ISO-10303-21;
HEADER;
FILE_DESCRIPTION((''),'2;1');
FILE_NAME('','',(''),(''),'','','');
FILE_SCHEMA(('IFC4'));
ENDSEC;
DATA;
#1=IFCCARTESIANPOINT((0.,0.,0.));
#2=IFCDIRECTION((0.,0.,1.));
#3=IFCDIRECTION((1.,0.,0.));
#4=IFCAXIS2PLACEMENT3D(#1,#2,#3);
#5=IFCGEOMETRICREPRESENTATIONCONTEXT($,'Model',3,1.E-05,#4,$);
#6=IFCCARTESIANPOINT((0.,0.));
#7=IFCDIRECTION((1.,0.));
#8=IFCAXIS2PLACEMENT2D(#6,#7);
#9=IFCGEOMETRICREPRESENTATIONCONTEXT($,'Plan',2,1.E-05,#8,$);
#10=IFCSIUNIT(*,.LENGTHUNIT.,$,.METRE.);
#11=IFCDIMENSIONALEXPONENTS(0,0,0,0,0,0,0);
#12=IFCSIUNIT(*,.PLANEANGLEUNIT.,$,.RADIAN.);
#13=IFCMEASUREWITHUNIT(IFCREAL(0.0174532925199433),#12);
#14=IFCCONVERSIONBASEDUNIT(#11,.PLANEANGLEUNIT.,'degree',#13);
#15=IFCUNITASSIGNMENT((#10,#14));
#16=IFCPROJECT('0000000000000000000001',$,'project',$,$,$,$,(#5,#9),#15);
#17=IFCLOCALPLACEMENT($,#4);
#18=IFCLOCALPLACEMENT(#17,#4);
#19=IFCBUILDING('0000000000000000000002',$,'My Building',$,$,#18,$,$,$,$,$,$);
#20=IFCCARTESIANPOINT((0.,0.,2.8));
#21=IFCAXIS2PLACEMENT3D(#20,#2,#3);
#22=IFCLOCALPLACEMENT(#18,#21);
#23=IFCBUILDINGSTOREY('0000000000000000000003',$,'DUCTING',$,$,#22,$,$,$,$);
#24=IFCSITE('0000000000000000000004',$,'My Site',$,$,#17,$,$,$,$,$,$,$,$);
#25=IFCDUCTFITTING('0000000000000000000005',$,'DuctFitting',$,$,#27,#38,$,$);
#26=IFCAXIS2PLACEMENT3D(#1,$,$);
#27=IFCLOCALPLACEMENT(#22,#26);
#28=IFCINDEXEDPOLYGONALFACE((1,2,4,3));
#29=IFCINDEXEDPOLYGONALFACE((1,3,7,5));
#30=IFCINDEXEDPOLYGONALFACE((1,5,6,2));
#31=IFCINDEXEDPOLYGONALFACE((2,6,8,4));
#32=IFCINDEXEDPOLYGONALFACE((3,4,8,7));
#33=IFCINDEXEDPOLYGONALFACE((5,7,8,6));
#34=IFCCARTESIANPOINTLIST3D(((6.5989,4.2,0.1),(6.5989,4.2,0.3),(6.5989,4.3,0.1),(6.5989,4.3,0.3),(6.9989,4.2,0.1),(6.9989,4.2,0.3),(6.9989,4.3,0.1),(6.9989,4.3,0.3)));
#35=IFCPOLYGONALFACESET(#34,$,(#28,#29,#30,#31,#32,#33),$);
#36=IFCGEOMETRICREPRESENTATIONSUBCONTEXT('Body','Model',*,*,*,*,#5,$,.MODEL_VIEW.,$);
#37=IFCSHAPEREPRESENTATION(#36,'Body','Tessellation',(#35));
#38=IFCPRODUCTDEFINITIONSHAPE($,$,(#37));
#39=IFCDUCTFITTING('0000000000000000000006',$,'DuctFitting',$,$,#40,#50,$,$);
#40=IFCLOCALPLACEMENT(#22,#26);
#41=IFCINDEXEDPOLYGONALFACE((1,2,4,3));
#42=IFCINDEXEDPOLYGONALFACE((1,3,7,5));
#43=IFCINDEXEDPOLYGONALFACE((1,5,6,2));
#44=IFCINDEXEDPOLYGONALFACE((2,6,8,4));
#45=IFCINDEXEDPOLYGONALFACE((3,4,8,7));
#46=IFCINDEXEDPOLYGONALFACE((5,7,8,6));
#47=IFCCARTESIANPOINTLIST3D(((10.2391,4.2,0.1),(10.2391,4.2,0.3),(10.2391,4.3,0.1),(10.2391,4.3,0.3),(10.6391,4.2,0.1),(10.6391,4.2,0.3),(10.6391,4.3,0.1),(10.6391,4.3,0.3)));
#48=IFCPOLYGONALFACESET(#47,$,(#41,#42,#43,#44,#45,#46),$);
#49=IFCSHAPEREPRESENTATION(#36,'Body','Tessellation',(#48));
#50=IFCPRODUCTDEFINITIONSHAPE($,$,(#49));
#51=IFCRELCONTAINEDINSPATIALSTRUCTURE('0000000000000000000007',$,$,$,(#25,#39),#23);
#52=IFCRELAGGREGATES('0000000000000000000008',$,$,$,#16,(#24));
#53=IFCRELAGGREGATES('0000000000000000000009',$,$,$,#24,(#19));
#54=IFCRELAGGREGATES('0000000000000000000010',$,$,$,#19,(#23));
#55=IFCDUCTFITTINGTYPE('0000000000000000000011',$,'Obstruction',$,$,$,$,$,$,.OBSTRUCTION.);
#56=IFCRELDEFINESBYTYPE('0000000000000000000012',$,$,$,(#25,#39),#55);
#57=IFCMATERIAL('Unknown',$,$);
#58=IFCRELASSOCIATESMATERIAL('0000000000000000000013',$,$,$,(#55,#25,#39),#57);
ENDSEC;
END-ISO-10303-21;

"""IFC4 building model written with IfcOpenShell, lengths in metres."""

from ifc_helpers import new_model, entity, si_unit, converted_unit, frame, origin_with_axes, origin_2d_with_axis, place, context, subcontext, project, spatial, rectangle, extrude, material, material_profile, profile_set, profile_usage, type_object, element, save


model = new_model("IFC4")

# Units and contexts
model_context = context("Model", 3, precision=1e-05, world=origin_with_axes())
plan_context = context("Plan", 2, precision=1e-05, world=origin_2d_with_axis())
body_context = subcontext(model_context, "Body", "Model", "MODEL_VIEW")
ifc_project = project(units=[si_unit("LENGTHUNIT", "METRE"), converted_unit("PLANEANGLEUNIT", "degree", entity("IfcReal", 0.0174532925199433), si_unit("PLANEANGLEUNIT", "RADIAN"), dimensions=[0, 0, 0, 0, 0, 0, 0])], contexts=[model_context, plan_context])

# Site, building, storey
site_placement = place(None, origin_with_axes())
site = spatial("IfcSite", under=ifc_project, at=site_placement, Name="My Site")
building_placement = place(site_placement, origin_with_axes())
building = spatial("IfcBuilding", under=site, at=building_placement, Name="My Building")
storey_placement = place(building_placement, frame((0.0, 0.0, 2.8), z_axis=(0.0, 0.0, 1.0), x_axis=(1.0, 0.0, 0.0)))
storey = spatial("IfcBuildingStorey", under=building, at=storey_placement, Name="DUCTING")

# Shared definitions
ifc_material = material(Name="Unknown")

# Duct fittings
ifc_material_profile_1 = material_profile(ifc_material, rectangle(XDim=0.4, YDim=0.2))
ifc_profile_set_1 = profile_set([ifc_material_profile_1])
duct_fitting_type_1 = type_object("IfcDuctFittingType", Name="Obstruction", PredefinedType="OBSTRUCTION", material=ifc_profile_set_1)
ifc_profile_usage_1 = profile_usage(ifc_profile_set_1, cardinal=5)
duct_fitting_1_placement = place(storey_placement, frame((6.7989, 4.3, 0.2), z_axis=(0.0, -1.0, 0.0), x_axis=(1.0, 0.0, 0.0)))
element("IfcDuctFitting", 1, at=duct_fitting_1_placement, inside=storey, type_object=duct_fitting_type_1, material=ifc_profile_usage_1, Name="DuctFitting", context=body_context, shape_type="SweptSolid", body=[
    extrude(rectangle(XDim=0.4, YDim=0.2), origin_with_axes(), (0.0, 0.0, 1.0), 0.1),
])
ifc_profile_usage_2 = profile_usage(ifc_profile_set_1, cardinal=5)
duct_fitting_2_placement = place(storey_placement, frame((10.4391, 4.3, 0.2), z_axis=(0.0, -1.0, 0.0), x_axis=(1.0, 0.0, 0.0)))
element("IfcDuctFitting", 2, at=duct_fitting_2_placement, inside=storey, type_object=duct_fitting_type_1, material=ifc_profile_usage_2, Name="DuctFitting", context=body_context, shape_type="SweptSolid", body=[
    extrude(rectangle(XDim=0.4, YDim=0.2), origin_with_axes(), (0.0, 0.0, 1.0), 0.1),
])

save(model, "model.ifc")
